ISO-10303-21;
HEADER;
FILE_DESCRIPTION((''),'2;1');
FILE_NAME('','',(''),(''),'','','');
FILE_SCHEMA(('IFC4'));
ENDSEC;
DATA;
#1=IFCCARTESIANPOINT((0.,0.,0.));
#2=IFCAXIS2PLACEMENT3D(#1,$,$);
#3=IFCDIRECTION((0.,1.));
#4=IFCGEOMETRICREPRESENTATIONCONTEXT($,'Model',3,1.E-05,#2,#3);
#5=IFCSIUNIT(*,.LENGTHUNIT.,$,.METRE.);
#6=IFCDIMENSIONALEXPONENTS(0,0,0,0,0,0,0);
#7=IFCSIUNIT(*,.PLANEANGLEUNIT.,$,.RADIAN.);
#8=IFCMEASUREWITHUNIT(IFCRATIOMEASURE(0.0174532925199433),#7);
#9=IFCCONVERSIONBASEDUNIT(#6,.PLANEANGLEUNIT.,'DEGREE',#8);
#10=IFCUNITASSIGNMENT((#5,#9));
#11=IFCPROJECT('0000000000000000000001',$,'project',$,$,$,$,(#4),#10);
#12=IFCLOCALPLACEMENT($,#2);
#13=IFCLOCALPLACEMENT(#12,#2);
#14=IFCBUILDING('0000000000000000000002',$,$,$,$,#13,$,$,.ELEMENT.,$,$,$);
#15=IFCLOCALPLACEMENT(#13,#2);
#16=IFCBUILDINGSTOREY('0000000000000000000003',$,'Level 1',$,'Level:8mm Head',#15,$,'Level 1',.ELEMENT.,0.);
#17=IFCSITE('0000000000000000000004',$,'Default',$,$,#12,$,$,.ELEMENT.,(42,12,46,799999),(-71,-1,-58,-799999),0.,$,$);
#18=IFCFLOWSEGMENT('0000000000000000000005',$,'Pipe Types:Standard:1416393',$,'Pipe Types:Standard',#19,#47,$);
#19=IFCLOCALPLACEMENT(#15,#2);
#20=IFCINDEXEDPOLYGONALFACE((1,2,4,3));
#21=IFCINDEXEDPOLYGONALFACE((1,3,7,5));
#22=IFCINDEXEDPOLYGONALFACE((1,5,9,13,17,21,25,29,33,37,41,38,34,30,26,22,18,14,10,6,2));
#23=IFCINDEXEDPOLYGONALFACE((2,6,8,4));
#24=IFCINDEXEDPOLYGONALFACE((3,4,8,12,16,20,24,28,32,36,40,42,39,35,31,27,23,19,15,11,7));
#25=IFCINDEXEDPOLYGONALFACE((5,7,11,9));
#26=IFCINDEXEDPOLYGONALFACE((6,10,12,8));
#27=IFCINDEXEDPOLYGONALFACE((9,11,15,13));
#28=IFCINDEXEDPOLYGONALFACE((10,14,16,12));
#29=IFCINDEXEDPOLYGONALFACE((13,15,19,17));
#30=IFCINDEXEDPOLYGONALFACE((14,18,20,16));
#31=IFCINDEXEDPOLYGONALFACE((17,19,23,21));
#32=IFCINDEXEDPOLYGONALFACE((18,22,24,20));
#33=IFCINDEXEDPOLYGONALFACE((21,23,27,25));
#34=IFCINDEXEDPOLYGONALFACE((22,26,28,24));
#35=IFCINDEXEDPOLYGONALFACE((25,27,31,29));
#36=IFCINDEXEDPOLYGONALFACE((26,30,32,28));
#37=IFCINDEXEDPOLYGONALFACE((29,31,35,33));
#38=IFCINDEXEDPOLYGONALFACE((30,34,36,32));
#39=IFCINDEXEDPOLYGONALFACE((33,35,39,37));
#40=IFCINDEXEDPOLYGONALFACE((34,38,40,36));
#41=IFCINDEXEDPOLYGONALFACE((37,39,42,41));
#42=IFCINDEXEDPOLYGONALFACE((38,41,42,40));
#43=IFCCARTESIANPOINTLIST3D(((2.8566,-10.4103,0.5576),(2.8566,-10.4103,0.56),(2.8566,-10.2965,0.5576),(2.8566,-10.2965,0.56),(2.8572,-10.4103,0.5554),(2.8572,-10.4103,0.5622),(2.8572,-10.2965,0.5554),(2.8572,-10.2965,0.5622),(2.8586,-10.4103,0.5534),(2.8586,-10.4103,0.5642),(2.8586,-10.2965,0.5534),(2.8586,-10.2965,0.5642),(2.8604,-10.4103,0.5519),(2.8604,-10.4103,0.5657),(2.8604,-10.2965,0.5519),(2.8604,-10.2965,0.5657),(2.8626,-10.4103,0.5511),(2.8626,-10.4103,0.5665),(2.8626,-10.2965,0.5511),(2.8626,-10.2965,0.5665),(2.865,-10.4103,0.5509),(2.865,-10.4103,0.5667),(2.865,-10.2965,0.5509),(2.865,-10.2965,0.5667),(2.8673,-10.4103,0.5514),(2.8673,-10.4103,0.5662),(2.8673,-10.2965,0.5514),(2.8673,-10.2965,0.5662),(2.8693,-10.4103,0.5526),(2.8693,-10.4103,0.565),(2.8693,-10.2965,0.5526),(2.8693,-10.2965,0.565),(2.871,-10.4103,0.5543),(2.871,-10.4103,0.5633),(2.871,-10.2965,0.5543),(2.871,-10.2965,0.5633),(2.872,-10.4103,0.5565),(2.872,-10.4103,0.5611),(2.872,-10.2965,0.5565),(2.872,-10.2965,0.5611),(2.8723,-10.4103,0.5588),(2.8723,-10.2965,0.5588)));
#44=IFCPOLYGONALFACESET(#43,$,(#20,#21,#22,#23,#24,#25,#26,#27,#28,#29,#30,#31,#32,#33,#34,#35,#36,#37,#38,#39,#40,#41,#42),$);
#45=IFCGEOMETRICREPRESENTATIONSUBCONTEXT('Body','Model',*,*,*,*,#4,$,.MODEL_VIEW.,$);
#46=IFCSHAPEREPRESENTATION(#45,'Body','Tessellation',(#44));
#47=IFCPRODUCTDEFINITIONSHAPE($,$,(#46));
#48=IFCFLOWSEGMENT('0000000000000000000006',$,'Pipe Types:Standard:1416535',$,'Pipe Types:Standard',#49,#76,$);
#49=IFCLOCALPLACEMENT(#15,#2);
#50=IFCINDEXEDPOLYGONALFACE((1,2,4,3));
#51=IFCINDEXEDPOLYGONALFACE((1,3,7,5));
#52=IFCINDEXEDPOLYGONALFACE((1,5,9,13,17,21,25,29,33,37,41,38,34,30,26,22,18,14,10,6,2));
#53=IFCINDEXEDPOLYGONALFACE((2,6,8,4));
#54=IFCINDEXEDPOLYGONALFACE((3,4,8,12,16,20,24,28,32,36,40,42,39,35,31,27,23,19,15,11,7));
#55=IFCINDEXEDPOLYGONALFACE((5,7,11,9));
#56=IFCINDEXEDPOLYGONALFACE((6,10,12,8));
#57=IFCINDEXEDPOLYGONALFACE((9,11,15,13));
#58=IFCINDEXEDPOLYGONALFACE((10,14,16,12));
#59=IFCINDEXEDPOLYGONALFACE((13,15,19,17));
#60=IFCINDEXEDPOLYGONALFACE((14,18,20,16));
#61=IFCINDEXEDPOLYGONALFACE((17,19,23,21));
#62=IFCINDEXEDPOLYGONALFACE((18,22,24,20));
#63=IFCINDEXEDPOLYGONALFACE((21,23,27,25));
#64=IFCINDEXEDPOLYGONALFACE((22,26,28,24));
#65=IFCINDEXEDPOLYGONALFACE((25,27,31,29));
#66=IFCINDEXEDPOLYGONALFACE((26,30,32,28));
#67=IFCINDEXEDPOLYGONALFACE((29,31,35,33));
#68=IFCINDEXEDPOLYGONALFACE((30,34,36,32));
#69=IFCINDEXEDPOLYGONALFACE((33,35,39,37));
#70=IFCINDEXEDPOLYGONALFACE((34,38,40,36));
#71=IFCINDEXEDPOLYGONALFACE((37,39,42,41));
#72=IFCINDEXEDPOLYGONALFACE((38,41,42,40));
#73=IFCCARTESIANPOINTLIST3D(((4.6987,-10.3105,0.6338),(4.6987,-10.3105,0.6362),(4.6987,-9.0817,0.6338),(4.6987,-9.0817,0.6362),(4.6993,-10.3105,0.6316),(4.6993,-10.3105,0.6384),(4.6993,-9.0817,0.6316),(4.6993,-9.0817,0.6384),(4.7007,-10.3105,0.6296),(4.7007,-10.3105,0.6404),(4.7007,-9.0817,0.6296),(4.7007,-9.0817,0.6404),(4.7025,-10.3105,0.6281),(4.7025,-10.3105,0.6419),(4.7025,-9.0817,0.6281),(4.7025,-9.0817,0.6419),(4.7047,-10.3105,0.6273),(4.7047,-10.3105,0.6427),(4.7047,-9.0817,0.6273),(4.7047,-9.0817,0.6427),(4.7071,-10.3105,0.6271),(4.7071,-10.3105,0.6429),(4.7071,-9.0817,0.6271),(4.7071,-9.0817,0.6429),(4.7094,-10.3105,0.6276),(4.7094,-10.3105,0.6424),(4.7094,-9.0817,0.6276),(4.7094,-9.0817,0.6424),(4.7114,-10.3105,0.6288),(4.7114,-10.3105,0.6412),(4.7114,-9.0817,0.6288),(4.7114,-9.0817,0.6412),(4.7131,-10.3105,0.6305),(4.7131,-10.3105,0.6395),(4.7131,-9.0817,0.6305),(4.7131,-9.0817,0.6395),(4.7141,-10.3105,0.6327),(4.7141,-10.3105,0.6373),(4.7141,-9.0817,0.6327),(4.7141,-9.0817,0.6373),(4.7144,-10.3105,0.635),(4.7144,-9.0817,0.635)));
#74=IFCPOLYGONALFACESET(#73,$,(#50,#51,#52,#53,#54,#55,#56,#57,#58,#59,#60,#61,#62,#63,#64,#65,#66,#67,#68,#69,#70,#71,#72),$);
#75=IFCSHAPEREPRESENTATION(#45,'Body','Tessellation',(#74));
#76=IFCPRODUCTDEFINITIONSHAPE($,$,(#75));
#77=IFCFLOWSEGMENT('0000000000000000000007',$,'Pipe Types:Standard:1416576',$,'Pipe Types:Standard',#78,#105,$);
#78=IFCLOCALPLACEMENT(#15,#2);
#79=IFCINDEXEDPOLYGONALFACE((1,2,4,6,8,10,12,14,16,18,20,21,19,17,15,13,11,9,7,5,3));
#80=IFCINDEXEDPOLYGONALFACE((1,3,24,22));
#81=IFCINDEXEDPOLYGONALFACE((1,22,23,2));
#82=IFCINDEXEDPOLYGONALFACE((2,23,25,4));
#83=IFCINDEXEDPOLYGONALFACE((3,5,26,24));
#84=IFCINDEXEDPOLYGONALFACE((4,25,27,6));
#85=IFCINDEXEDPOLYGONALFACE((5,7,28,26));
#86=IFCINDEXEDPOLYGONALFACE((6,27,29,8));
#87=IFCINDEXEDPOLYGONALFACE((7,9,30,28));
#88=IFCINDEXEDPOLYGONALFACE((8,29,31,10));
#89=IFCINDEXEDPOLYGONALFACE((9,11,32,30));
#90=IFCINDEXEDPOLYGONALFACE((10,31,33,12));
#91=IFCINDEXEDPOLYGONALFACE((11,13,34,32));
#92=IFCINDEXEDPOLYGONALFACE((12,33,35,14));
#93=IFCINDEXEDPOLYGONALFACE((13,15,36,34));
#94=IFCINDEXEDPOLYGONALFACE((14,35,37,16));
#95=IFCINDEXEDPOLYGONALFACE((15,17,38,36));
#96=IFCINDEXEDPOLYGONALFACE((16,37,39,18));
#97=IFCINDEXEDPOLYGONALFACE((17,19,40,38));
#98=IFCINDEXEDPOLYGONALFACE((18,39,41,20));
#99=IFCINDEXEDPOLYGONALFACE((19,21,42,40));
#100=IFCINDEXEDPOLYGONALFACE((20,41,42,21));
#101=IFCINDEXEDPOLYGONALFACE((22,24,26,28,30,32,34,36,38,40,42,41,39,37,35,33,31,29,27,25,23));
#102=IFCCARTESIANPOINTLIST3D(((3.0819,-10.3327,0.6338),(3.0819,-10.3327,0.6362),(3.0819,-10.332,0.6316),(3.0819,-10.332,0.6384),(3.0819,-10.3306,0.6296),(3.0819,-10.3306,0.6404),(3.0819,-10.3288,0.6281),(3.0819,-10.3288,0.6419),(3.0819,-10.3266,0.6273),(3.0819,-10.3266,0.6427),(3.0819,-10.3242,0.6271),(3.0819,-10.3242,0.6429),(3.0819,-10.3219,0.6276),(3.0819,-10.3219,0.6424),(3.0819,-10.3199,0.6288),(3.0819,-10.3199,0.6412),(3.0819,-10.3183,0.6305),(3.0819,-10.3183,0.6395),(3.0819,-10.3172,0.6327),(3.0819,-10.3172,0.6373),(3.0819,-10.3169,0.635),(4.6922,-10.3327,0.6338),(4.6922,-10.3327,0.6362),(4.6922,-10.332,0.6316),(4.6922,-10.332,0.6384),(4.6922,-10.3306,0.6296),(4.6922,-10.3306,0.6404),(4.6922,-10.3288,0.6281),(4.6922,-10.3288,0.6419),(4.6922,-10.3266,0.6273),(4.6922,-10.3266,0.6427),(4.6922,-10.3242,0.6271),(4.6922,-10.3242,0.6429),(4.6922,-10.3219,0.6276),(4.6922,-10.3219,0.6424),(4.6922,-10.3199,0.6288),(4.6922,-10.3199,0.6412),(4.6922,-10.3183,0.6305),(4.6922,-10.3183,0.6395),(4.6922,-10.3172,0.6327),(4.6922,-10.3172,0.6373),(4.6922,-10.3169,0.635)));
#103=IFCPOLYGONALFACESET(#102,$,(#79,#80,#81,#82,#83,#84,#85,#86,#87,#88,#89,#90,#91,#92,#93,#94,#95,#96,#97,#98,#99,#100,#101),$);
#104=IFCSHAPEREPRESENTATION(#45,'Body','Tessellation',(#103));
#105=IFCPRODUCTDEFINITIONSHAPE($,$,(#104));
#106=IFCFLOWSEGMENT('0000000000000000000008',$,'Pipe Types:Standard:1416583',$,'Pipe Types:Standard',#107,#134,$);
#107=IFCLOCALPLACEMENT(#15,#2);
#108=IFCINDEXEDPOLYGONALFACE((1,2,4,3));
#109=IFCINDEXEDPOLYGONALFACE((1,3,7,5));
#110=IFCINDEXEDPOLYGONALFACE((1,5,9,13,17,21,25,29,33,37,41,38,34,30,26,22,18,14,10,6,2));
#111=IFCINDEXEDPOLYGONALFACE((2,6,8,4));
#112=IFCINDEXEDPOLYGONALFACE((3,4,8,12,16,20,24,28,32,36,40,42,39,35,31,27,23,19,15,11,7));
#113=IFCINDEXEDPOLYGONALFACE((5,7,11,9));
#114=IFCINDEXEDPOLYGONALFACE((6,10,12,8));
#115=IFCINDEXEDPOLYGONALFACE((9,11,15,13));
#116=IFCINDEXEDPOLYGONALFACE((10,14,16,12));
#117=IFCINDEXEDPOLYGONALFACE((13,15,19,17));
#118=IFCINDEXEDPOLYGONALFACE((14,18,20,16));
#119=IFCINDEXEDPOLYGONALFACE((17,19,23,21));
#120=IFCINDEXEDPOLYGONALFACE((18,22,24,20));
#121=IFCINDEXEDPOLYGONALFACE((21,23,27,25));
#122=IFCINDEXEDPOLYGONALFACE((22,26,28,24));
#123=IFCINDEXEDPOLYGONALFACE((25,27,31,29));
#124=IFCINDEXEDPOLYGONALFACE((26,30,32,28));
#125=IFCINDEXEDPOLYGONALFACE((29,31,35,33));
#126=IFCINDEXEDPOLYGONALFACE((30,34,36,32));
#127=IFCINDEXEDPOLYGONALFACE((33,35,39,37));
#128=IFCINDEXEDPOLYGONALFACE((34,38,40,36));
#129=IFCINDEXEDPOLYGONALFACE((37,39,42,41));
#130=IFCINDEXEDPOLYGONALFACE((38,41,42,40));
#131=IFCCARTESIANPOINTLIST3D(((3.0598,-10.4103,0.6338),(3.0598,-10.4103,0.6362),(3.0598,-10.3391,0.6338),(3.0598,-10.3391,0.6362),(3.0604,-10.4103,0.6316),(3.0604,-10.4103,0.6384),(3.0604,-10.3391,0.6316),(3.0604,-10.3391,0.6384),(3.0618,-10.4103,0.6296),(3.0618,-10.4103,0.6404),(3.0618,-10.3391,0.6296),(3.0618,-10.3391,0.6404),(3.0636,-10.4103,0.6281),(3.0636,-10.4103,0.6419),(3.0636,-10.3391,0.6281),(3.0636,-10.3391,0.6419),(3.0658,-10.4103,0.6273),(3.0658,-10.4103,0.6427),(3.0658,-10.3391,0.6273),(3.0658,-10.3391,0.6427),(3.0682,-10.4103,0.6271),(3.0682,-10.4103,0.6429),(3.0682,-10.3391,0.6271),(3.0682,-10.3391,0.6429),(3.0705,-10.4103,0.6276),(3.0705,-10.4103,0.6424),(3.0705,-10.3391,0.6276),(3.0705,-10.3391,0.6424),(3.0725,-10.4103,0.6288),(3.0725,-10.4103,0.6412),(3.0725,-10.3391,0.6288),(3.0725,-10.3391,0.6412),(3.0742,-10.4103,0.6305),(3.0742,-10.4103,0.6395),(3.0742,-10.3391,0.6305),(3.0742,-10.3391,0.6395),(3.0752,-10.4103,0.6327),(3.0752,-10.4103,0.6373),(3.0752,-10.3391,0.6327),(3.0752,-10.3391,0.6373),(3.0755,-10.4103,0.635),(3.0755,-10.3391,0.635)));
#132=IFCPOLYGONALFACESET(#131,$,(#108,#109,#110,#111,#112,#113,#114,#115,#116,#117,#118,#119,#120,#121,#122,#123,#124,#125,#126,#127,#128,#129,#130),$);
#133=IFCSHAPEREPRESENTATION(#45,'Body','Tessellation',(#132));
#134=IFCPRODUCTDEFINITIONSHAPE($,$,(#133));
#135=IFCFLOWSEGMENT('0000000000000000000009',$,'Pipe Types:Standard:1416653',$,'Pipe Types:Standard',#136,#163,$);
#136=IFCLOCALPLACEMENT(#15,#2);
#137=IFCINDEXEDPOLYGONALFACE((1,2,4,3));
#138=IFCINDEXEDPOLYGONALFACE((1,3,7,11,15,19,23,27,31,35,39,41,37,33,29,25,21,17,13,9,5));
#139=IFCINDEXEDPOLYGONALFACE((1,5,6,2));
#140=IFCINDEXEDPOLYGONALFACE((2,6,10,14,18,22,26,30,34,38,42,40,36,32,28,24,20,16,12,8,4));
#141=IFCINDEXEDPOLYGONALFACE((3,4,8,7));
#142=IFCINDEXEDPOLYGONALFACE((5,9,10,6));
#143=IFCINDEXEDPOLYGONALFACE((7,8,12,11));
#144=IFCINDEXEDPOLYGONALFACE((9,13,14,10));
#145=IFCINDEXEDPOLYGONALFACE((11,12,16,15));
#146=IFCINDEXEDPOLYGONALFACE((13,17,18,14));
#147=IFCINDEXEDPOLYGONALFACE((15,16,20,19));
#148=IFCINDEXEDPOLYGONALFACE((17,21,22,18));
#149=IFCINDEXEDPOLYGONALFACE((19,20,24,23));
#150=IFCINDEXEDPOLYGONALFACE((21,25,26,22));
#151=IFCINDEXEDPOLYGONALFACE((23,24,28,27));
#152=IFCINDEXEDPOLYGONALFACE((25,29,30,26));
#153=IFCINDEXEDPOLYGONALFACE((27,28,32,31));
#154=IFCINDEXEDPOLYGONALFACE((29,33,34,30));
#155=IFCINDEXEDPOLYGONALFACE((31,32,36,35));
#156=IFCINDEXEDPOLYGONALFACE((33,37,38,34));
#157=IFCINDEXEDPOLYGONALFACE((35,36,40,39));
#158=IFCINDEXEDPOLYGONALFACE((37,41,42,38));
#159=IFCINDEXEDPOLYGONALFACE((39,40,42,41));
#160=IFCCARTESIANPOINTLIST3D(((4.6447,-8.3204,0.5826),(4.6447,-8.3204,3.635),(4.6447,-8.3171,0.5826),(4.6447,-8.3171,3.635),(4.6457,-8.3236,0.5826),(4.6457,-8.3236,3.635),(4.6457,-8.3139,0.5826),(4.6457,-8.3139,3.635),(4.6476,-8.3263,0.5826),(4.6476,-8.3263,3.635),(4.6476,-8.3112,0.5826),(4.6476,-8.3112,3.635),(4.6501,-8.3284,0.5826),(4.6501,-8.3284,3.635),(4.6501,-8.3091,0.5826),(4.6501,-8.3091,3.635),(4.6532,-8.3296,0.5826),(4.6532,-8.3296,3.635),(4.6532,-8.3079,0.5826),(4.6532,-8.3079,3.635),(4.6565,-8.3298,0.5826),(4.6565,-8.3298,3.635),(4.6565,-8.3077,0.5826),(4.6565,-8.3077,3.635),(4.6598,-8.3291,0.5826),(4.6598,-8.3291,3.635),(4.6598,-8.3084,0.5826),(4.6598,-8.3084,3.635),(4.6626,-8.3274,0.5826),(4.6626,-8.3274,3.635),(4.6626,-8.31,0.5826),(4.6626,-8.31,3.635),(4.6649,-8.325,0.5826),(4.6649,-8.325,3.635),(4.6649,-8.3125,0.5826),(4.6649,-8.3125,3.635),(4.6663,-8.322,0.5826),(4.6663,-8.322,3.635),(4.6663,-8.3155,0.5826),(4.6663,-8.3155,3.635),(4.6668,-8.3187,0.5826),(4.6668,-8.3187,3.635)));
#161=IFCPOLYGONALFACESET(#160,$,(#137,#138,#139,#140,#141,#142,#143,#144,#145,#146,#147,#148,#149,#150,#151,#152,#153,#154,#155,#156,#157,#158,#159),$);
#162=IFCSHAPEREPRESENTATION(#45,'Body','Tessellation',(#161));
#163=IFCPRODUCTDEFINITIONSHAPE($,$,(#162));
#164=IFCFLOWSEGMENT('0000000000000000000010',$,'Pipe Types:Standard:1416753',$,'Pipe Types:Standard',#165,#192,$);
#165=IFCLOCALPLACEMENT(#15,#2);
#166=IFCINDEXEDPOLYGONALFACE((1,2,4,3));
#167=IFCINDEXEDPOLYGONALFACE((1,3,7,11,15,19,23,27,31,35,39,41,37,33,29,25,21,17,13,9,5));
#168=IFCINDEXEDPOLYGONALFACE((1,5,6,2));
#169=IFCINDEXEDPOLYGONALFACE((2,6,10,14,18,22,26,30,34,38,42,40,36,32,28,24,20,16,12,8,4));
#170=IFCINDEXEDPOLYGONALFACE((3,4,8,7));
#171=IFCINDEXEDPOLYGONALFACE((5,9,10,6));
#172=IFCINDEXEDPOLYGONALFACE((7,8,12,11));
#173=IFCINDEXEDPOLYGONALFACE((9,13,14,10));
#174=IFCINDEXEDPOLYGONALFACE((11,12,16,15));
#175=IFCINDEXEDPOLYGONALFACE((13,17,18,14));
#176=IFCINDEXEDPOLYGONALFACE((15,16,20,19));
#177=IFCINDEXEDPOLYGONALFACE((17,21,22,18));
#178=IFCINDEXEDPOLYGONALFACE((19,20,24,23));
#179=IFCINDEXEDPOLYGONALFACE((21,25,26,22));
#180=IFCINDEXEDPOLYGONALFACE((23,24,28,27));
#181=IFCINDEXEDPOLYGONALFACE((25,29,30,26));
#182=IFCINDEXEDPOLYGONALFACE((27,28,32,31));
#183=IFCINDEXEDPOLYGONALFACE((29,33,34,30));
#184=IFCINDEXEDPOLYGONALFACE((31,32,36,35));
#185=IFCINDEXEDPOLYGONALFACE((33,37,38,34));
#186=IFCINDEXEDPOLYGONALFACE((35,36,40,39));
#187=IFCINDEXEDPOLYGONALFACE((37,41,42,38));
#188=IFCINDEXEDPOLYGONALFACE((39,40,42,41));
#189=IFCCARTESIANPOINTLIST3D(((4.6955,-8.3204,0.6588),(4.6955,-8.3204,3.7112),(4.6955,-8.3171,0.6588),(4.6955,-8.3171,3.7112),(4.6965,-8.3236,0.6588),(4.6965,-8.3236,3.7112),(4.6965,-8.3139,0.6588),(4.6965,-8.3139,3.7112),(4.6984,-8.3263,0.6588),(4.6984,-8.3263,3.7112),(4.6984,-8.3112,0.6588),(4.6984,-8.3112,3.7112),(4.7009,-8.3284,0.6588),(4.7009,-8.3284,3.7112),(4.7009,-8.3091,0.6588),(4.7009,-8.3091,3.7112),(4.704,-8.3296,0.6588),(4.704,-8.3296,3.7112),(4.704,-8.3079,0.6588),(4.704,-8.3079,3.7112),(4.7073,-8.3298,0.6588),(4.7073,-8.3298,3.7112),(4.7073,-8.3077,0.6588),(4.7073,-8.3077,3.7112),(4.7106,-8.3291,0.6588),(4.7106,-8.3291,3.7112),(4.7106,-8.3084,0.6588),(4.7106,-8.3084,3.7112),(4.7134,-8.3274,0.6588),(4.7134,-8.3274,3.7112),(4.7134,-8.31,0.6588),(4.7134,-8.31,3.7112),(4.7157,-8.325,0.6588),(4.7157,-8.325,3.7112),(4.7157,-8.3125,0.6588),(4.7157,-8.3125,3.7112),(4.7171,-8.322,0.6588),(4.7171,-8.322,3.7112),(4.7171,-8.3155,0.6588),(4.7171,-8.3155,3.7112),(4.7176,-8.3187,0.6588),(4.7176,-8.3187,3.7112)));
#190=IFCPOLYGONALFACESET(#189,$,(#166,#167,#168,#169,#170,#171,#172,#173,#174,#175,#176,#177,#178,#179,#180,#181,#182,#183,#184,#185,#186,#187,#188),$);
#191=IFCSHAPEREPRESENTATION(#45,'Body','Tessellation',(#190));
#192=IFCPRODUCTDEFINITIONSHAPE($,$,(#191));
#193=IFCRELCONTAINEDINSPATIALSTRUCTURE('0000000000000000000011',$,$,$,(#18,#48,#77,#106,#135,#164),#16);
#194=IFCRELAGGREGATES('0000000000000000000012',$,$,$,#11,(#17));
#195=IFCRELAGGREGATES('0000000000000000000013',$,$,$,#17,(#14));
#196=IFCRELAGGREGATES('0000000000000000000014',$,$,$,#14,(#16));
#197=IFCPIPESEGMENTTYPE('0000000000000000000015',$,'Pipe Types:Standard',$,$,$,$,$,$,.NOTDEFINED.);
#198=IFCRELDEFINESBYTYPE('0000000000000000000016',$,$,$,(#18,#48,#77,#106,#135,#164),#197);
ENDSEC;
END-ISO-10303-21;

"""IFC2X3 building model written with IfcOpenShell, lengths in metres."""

from ifc_helpers import new_model, entity, si_unit, converted_unit, direction, frame, frame_2d, origin, origin_2d_with_axis, place, context, subcontext, project, spatial, circle, extrude, type_object, element, save


model = new_model("IFC2X3")

# Units and contexts
model_context = context("Model", 3, precision=1e-05, world=origin(), true_north=direction((0.0, 1.0)))
body_context = subcontext(model_context, "Body", "Model", "MODEL_VIEW")
ifc_project = project(units=[si_unit("LENGTHUNIT", "METRE"), converted_unit("PLANEANGLEUNIT", "DEGREE", entity("IfcRatioMeasure", 0.0174532925199433), si_unit("PLANEANGLEUNIT", "RADIAN"), dimensions=[0, 0, 0, 0, 0, 0, 0])], contexts=[model_context])

# Site, building, storey
site_placement = place(None, origin())
site = spatial("IfcSite", under=ifc_project, at=site_placement, Name="Default", CompositionType="ELEMENT", RefLatitude=(42, 12, 46, 799999), RefLongitude=(-71, -1, -58, -799999), RefElevation=0.0)
building_placement = place(site_placement, origin())
building = spatial("IfcBuilding", under=site, at=building_placement, CompositionType="ELEMENT")
storey_placement = place(building_placement, origin())
storey = spatial("IfcBuildingStorey", under=building, at=storey_placement, Name="Level 1", ObjectType="Level:8mm Head", LongName="Level 1", CompositionType="ELEMENT", Elevation=0.0)

# Flow segments
pipe_segment_type = type_object("IfcPipeSegmentType", Name="Pipe Types:Standard", PredefinedType="NOTDEFINED")
flow_segment_1_placement = place(storey_placement, origin())
element("IfcFlowSegment", 1, at=flow_segment_1_placement, inside=storey, type_object=pipe_segment_type, Name="Pipe Types:Standard:1416393", ObjectType="Pipe Types:Standard", context=body_context, shape_type="SweptSolid", body=[
    extrude(circle(Radius=0.0079, at=frame_2d((0.0, 0.0), x_axis=(1.0, 0.0))), frame((2.8644, -10.4103, 0.5588), z_axis=(0.0, 1.0, 0.0), x_axis=(1.0, 0.0, 0.0)), (0.0, 0.0, 1.0), 0.1138),
])
flow_segment_2_placement = place(storey_placement, origin())
element("IfcFlowSegment", 2, at=flow_segment_2_placement, inside=storey, type_object=pipe_segment_type, Name="Pipe Types:Standard:1416535", ObjectType="Pipe Types:Standard", context=body_context, shape_type="SweptSolid", body=[
    extrude(circle(Radius=0.0079, at=origin_2d_with_axis()), frame((4.7065, -10.3105, 0.635), z_axis=(0.0, 1.0, 0.0), x_axis=(1.0, 0.0, 0.0)), (0.0, 0.0, 1.0), 1.2289),
])
flow_segment_3_placement = place(storey_placement, origin())
element("IfcFlowSegment", 3, at=flow_segment_3_placement, inside=storey, type_object=pipe_segment_type, Name="Pipe Types:Standard:1416576", ObjectType="Pipe Types:Standard", context=body_context, shape_type="SweptSolid", body=[
    extrude(circle(Radius=0.0079, at=frame_2d((0.0, 0.0), x_axis=(1.0, 0.0))), frame((3.0819, -10.3248, 0.635), z_axis=(1.0, 0.0, 0.0), x_axis=(0.0, 1.0, 0.0)), (0.0, 0.0, 1.0), 1.6103),
])
flow_segment_4_placement = place(storey_placement, origin())
element("IfcFlowSegment", 4, at=flow_segment_4_placement, inside=storey, type_object=pipe_segment_type, Name="Pipe Types:Standard:1416583", ObjectType="Pipe Types:Standard", context=body_context, shape_type="SweptSolid", body=[
    extrude(circle(Radius=0.0079, at=origin_2d_with_axis()), frame((3.0676, -10.4103, 0.635), z_axis=(0.0, 1.0, 0.0), x_axis=(1.0, 0.0, 0.0)), (0.0, 0.0, 1.0), 0.0712),
])
flow_segment_5_placement = place(storey_placement, origin())
element("IfcFlowSegment", 5, at=flow_segment_5_placement, inside=storey, type_object=pipe_segment_type, Name="Pipe Types:Standard:1416653", ObjectType="Pipe Types:Standard", context=body_context, shape_type="SweptSolid", body=[
    extrude(circle(Radius=0.0111, at=frame_2d((0.0, 0.0), x_axis=(1.0, 0.0))), frame((4.6557, -8.3187, 0.5826)), (0.0, 0.0, 1.0), 3.0524),
])
flow_segment_6_placement = place(storey_placement, origin())
element("IfcFlowSegment", 6, at=flow_segment_6_placement, inside=storey, type_object=pipe_segment_type, Name="Pipe Types:Standard:1416753", ObjectType="Pipe Types:Standard", context=body_context, shape_type="SweptSolid", body=[
    extrude(circle(Radius=0.0111, at=origin_2d_with_axis()), frame((4.7065, -8.3187, 0.6588)), (0.0, 0.0, 1.0), 3.0524),
])

save(model, "model.ifc")
